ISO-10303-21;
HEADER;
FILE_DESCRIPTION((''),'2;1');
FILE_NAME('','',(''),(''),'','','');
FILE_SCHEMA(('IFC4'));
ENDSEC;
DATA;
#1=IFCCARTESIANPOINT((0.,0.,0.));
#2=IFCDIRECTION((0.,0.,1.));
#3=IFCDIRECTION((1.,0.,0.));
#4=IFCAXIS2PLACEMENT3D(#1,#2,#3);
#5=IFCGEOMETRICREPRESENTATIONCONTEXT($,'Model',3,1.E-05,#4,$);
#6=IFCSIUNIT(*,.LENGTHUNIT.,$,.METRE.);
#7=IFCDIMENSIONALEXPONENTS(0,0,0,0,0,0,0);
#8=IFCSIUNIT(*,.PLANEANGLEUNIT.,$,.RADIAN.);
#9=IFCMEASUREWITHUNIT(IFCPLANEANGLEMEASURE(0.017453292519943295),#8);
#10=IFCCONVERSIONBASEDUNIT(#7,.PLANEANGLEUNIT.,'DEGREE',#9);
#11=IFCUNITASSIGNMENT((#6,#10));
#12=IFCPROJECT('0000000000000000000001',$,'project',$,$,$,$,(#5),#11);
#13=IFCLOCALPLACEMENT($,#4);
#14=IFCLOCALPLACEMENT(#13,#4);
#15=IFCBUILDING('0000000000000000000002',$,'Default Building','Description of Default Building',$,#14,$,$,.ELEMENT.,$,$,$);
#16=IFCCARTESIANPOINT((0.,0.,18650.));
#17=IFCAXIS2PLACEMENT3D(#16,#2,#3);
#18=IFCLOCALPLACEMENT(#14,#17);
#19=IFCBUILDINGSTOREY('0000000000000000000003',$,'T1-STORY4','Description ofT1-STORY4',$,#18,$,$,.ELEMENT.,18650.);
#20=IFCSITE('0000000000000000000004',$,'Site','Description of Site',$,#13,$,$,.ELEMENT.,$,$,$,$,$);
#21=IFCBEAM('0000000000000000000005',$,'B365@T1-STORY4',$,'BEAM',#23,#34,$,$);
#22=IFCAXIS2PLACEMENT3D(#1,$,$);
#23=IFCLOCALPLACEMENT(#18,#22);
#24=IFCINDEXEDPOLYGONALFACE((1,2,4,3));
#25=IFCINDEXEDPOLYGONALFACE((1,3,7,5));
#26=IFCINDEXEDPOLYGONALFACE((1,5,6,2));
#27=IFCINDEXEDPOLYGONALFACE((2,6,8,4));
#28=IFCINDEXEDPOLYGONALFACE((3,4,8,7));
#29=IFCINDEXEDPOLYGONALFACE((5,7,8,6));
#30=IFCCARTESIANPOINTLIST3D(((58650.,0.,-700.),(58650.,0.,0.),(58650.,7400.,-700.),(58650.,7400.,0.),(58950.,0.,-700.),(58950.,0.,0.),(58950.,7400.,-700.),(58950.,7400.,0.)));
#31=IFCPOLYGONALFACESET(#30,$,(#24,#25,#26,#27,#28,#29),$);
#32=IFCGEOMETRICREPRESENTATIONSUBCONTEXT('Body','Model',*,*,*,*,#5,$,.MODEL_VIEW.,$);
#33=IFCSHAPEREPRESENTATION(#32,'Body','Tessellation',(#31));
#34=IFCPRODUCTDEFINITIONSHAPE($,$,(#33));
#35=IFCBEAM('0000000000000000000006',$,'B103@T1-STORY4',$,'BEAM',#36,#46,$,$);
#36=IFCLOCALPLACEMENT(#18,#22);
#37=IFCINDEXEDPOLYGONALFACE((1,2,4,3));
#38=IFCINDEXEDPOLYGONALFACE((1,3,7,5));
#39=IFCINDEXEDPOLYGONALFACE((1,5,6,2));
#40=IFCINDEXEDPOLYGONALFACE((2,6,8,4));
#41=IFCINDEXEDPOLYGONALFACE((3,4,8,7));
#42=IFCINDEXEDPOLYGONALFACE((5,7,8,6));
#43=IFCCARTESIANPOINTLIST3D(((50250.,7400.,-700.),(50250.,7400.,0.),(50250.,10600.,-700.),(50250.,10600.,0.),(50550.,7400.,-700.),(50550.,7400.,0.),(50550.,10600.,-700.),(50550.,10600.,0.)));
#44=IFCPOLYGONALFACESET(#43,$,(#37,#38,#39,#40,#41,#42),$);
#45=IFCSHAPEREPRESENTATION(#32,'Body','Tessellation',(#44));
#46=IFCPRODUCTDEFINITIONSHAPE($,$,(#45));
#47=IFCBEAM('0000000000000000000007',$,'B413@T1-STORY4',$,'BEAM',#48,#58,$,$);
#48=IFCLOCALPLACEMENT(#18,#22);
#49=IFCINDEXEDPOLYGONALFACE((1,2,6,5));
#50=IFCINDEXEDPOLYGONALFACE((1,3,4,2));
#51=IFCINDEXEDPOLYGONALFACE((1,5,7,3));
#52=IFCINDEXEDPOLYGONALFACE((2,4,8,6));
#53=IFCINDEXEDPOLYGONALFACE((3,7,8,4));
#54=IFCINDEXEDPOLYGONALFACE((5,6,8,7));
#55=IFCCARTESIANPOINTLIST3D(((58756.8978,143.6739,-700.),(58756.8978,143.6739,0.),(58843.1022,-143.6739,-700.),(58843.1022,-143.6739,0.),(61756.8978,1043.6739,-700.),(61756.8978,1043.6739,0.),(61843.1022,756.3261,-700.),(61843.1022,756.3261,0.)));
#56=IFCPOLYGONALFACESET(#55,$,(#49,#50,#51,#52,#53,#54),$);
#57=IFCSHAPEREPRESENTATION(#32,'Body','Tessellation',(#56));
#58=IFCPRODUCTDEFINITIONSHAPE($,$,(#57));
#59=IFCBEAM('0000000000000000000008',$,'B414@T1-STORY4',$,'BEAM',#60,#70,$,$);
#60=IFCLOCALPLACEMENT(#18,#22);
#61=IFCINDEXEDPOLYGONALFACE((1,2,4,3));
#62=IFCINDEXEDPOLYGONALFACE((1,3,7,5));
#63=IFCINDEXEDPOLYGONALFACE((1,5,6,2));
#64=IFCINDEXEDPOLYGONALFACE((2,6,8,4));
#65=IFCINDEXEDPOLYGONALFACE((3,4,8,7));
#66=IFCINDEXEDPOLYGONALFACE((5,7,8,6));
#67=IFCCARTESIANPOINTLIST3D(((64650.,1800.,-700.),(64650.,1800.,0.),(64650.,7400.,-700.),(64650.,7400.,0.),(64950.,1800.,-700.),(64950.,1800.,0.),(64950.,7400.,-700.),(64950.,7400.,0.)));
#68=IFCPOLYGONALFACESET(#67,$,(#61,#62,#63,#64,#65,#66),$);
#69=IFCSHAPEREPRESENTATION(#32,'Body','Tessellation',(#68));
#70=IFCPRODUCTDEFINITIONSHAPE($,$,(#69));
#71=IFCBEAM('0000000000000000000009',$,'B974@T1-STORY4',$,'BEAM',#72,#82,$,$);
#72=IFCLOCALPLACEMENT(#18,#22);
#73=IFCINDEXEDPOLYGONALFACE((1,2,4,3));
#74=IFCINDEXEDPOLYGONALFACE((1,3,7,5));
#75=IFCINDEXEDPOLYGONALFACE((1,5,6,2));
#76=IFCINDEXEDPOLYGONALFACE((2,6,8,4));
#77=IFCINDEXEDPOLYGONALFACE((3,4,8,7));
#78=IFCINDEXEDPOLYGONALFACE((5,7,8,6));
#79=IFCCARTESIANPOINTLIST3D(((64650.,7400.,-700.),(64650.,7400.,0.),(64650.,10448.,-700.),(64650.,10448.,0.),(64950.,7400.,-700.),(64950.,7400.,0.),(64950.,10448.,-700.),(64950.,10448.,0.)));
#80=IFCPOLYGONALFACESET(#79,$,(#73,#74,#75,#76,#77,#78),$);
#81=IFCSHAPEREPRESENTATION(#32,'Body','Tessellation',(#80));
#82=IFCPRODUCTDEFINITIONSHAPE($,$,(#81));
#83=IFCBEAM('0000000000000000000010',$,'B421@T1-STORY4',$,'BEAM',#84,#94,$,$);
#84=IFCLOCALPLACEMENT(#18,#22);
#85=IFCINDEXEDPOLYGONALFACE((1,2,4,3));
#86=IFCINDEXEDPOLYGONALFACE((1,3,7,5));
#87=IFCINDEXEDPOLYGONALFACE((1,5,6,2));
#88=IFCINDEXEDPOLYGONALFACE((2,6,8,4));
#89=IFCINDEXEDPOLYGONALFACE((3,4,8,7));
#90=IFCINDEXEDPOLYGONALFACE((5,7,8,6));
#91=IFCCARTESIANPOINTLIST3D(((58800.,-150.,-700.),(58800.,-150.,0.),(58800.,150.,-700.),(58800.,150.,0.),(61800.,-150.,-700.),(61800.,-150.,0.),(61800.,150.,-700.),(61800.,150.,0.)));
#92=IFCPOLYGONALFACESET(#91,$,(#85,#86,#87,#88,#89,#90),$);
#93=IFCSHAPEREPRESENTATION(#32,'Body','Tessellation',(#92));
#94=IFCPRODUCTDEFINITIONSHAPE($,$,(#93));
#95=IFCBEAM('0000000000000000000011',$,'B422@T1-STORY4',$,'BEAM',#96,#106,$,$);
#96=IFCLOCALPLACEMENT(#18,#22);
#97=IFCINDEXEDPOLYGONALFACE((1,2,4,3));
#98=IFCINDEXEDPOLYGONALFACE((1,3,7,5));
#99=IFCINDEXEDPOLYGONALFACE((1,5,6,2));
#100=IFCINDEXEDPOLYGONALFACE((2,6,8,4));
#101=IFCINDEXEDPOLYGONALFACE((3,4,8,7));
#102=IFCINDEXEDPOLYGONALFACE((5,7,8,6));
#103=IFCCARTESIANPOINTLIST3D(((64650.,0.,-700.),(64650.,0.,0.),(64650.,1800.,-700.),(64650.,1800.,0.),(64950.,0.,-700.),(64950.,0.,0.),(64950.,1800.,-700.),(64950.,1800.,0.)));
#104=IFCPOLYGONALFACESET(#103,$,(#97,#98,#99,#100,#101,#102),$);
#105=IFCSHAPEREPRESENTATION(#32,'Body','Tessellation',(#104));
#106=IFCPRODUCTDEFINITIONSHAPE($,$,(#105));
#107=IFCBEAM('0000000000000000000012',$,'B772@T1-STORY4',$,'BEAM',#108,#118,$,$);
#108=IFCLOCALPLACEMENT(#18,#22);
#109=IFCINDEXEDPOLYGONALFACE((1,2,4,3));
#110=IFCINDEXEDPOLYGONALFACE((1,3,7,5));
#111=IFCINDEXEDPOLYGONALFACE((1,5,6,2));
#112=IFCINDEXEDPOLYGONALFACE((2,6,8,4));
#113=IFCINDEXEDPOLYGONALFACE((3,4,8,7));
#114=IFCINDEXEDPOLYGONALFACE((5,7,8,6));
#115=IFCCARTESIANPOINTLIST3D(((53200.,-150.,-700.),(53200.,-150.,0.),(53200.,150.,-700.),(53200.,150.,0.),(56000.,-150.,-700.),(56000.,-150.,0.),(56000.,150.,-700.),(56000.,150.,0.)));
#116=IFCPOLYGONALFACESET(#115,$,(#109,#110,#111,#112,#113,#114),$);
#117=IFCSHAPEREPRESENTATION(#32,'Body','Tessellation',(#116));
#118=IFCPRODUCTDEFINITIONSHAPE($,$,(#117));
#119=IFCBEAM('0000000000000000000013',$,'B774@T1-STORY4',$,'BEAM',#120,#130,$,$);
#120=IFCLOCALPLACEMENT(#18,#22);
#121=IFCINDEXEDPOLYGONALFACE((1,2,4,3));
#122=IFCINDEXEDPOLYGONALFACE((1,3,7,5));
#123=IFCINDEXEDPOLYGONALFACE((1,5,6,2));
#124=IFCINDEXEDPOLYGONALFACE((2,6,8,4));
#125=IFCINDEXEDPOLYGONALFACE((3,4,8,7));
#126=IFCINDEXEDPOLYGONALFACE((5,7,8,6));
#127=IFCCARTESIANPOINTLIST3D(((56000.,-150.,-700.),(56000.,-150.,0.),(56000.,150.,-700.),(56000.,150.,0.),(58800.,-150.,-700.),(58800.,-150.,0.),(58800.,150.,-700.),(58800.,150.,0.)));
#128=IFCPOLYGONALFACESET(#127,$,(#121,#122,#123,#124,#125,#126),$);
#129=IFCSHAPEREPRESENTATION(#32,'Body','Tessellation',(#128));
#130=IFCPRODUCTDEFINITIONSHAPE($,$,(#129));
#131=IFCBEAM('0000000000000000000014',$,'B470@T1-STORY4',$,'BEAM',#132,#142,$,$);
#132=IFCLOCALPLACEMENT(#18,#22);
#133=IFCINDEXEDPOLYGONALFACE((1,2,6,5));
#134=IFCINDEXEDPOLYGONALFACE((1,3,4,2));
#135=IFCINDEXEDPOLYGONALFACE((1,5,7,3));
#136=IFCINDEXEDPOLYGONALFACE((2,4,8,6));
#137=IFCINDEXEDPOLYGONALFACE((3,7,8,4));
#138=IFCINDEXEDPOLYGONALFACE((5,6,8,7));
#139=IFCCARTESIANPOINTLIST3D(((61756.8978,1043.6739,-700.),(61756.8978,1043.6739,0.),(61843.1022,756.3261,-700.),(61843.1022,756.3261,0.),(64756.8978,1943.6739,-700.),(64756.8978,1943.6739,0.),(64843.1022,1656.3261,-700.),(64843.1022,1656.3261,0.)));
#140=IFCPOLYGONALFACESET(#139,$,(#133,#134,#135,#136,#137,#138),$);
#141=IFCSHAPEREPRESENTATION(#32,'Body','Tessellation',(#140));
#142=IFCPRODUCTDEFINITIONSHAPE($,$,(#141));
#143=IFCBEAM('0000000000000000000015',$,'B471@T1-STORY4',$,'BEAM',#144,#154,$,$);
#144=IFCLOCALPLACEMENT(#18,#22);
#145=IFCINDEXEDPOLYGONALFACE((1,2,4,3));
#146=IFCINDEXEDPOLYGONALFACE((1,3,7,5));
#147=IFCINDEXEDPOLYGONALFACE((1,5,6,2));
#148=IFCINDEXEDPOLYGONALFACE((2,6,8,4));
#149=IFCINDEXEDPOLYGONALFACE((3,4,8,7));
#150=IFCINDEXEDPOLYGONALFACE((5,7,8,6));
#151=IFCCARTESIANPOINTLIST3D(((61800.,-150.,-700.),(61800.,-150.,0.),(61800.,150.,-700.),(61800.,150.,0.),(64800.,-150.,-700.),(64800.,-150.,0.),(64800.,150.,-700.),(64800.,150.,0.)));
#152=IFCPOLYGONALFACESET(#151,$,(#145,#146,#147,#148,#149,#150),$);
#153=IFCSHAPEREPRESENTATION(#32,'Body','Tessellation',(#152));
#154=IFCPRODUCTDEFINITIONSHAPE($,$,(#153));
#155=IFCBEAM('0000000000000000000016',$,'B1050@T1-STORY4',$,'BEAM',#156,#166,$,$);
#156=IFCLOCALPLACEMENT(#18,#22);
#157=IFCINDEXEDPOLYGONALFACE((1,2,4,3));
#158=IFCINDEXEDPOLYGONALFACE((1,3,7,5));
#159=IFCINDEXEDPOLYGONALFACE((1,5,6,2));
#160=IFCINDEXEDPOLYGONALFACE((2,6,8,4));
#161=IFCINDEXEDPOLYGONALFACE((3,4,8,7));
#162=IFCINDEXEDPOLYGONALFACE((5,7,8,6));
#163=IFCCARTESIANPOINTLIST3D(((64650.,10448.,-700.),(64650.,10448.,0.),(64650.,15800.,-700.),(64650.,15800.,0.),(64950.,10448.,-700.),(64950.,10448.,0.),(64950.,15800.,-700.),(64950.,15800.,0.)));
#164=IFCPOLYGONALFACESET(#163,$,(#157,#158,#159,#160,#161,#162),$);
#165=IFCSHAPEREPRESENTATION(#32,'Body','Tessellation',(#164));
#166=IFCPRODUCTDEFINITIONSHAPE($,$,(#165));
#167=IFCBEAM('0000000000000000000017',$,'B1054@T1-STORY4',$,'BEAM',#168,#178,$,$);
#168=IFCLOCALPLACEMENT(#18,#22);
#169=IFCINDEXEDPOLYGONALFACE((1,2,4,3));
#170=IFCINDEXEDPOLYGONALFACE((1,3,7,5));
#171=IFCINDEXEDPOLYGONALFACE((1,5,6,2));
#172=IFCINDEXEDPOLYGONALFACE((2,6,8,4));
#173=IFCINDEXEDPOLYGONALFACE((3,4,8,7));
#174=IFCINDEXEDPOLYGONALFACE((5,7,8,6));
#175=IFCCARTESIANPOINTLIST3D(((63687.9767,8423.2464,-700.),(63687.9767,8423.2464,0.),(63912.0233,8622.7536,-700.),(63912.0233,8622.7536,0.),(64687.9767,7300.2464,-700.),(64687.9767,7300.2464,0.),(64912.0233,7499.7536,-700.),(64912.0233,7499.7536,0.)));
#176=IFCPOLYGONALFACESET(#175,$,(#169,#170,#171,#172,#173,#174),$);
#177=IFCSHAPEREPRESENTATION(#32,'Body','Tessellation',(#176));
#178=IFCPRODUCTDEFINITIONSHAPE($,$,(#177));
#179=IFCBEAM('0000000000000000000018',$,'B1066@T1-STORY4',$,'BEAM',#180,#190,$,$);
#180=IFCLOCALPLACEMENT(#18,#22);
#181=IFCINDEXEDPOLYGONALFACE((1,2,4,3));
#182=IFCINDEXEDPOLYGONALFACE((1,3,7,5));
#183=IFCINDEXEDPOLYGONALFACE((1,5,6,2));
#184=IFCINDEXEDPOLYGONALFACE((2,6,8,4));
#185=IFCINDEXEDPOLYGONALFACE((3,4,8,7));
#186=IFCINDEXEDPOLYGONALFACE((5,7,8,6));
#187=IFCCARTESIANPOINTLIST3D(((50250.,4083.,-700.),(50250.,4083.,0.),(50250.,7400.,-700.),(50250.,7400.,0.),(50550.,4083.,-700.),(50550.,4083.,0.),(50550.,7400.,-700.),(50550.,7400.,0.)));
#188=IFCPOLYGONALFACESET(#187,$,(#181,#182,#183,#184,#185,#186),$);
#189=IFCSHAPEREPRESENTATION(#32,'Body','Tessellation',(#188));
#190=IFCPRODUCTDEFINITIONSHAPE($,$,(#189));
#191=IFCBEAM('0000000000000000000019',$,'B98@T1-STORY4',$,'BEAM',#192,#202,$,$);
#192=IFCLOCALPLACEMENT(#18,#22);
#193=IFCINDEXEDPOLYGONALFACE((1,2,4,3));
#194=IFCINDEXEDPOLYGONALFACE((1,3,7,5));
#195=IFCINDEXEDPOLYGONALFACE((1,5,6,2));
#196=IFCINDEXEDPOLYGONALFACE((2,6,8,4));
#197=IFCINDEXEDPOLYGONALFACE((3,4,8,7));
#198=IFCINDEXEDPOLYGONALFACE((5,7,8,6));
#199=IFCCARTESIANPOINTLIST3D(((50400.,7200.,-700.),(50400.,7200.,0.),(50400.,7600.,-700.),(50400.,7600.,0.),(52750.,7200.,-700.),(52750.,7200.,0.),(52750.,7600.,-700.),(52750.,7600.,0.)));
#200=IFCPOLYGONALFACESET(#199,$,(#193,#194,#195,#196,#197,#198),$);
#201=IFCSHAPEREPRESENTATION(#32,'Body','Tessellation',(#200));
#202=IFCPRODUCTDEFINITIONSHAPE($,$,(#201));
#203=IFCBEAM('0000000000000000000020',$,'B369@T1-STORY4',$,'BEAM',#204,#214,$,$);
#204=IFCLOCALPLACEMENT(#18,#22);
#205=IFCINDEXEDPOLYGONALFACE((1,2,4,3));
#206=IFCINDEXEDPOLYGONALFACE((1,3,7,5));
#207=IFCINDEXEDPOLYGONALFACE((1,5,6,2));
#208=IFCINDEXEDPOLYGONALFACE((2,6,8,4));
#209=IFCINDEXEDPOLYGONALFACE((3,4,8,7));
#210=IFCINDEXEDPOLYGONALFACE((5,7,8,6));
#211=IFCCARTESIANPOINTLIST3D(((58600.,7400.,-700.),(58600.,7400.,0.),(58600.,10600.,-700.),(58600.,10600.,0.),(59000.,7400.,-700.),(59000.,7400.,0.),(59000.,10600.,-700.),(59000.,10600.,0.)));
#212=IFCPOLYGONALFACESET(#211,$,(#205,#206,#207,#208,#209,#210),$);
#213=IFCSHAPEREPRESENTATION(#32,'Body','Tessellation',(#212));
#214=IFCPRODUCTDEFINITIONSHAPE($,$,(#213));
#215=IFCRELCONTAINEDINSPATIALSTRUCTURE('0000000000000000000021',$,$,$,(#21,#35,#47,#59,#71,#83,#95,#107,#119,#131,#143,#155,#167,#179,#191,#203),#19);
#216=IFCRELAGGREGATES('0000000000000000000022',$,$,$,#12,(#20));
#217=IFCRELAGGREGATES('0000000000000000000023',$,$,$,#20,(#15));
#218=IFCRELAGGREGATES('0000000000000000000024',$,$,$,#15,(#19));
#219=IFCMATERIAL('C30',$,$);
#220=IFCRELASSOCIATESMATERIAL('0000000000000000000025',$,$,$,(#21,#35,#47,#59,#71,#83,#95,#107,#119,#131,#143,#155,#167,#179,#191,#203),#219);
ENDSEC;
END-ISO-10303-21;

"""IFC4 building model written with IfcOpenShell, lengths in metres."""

from ifc_helpers import new_model, entity, si_unit, converted_unit, frame, origin_with_axes, place, context, subcontext, project, spatial, rectangle, extrude, material, element, save


model = new_model("IFC4")

# Units and contexts
model_context = context("Model", 3, precision=1e-05, world=origin_with_axes())
body_context = subcontext(model_context, "Body", "Model", "MODEL_VIEW")
ifc_project = project(units=[si_unit("LENGTHUNIT", "METRE"), converted_unit("PLANEANGLEUNIT", "DEGREE", entity("IfcPlaneAngleMeasure", 0.017453292519943295), si_unit("PLANEANGLEUNIT", "RADIAN"), dimensions=[0, 0, 0, 0, 0, 0, 0])], contexts=[model_context])

# Site, building, storey
site_placement = place(None, origin_with_axes())
site = spatial("IfcSite", under=ifc_project, at=site_placement, Name="Site", Description="Description of Site", CompositionType="ELEMENT")
building_placement = place(site_placement, origin_with_axes())
building = spatial("IfcBuilding", under=site, at=building_placement, Name="Default Building", Description="Description of Default Building", CompositionType="ELEMENT")
storey_placement = place(building_placement, frame((0.0, 0.0, 18650.0), z_axis=(0.0, 0.0, 1.0), x_axis=(1.0, 0.0, 0.0)))
storey = spatial("IfcBuildingStorey", under=building, at=storey_placement, Name="T1-STORY4", Description="Description ofT1-STORY4", CompositionType="ELEMENT", Elevation=18650.0)

# Beams
ifc_material_1 = material(Name="C30")
beam_1_placement = place(storey_placement, frame((58800.0, 0.0, -350.0), z_axis=(0.0, 1.0, 0.0), x_axis=(-1.0, 0.0, 0.0)))
element("IfcBeam", 1, at=beam_1_placement, inside=storey, material=ifc_material_1, Name="B365@T1-STORY4", ObjectType="BEAM", context=body_context, shape_type="SweptSolid", body=[
    extrude(rectangle(XDim=300.0, YDim=700.0), origin_with_axes(), (0.0, 0.0, 1.0), 7400.0),
])
beam_2_placement = place(storey_placement, frame((50400.0, 7400.0, -350.0), z_axis=(0.0, 1.0, 0.0), x_axis=(-1.0, 0.0, 0.0)))
element("IfcBeam", 2, at=beam_2_placement, inside=storey, material=ifc_material_1, Name="B103@T1-STORY4", ObjectType="BEAM", context=body_context, shape_type="SweptSolid", body=[
    extrude(rectangle(XDim=300.0, YDim=700.0), origin_with_axes(), (0.0, 0.0, 1.0), 3200.0),
])
beam_3_placement = place(storey_placement, frame((58800.0, 0.0, -350.0), z_axis=(0.957826, 0.287348, 0.0), x_axis=(-0.287348, 0.957826, 0.0)))
element("IfcBeam", 3, at=beam_3_placement, inside=storey, material=ifc_material_1, Name="B413@T1-STORY4", ObjectType="BEAM", context=body_context, shape_type="SweptSolid", body=[
    extrude(rectangle(XDim=300.0, YDim=700.0), origin_with_axes(), (0.0, 0.0, 1.0), 3132.092),
])
beam_4_placement = place(storey_placement, frame((64800.0, 1800.0, -350.0), z_axis=(0.0, 1.0, 0.0), x_axis=(-1.0, 0.0, 0.0)))
element("IfcBeam", 4, at=beam_4_placement, inside=storey, material=ifc_material_1, Name="B414@T1-STORY4", ObjectType="BEAM", context=body_context, shape_type="SweptSolid", body=[
    extrude(rectangle(XDim=300.0, YDim=700.0), origin_with_axes(), (0.0, 0.0, 1.0), 5600.0),
])
beam_5_placement = place(storey_placement, frame((64800.0, 7400.0, -350.0), z_axis=(0.0, 1.0, 0.0), x_axis=(-1.0, 0.0, 0.0)))
element("IfcBeam", 5, at=beam_5_placement, inside=storey, material=ifc_material_1, Name="B974@T1-STORY4", ObjectType="BEAM", context=body_context, shape_type="SweptSolid", body=[
    extrude(rectangle(XDim=300.0, YDim=700.0), origin_with_axes(), (0.0, 0.0, 1.0), 3048.0),
])
beam_6_placement = place(storey_placement, frame((58800.0, 0.0, -350.0), z_axis=(1.0, 0.0, 0.0), x_axis=(0.0, 1.0, 0.0)))
element("IfcBeam", 6, at=beam_6_placement, inside=storey, material=ifc_material_1, Name="B421@T1-STORY4", ObjectType="BEAM", context=body_context, shape_type="SweptSolid", body=[
    extrude(rectangle(XDim=300.0, YDim=700.0), origin_with_axes(), (0.0, 0.0, 1.0), 3000.0),
])
beam_7_placement = place(storey_placement, frame((64800.0, 0.0, -350.0), z_axis=(0.0, 1.0, 0.0), x_axis=(-1.0, 0.0, 0.0)))
element("IfcBeam", 7, at=beam_7_placement, inside=storey, material=ifc_material_1, Name="B422@T1-STORY4", ObjectType="BEAM", context=body_context, shape_type="SweptSolid", body=[
    extrude(rectangle(XDim=300.0, YDim=700.0), origin_with_axes(), (0.0, 0.0, 1.0), 1800.0),
])
for number, where, z_axis, x_axis, name in (
    (8, (53200.0, 0.0, -350.0), (1.0, 0.0, 0.0), (0.0, 1.0, 0.0), "B772@T1-STORY4"),
    (9, (56000.0, 0.0, -350.0), (1.0, 0.0, 0.0), (0.0, 1.0, 0.0), "B774@T1-STORY4"),
):
    element("IfcBeam", number, at=place(storey_placement, frame(where, z_axis=z_axis, x_axis=x_axis)), inside=storey, material=ifc_material_1, Name=name, ObjectType="BEAM", context=body_context, shape_type="SweptSolid", body=[
        extrude(rectangle(XDim=300.0, YDim=700.0), origin_with_axes(), (0.0, 0.0, 1.0), 2800.0),
    ])
beam_8_placement = place(storey_placement, frame((61800.0, 900.0, -350.0), z_axis=(0.957826, 0.287348, 0.0), x_axis=(-0.287348, 0.957826, 0.0)))
element("IfcBeam", 10, at=beam_8_placement, inside=storey, material=ifc_material_1, Name="B470@T1-STORY4", ObjectType="BEAM", context=body_context, shape_type="SweptSolid", body=[
    extrude(rectangle(XDim=300.0, YDim=700.0), origin_with_axes(), (0.0, 0.0, 1.0), 3132.092),
])
beam_9_placement = place(storey_placement, frame((61800.0, 0.0, -350.0), z_axis=(1.0, 0.0, 0.0), x_axis=(0.0, 1.0, 0.0)))
element("IfcBeam", 11, at=beam_9_placement, inside=storey, material=ifc_material_1, Name="B471@T1-STORY4", ObjectType="BEAM", context=body_context, shape_type="SweptSolid", body=[
    extrude(rectangle(XDim=300.0, YDim=700.0), origin_with_axes(), (0.0, 0.0, 1.0), 3000.0),
])
beam_10_placement = place(storey_placement, frame((64800.0, 10448.0, -350.0), z_axis=(0.0, 1.0, 0.0), x_axis=(-1.0, 0.0, 0.0)))
element("IfcBeam", 12, at=beam_10_placement, inside=storey, material=ifc_material_1, Name="B1050@T1-STORY4", ObjectType="BEAM", context=body_context, shape_type="SweptSolid", body=[
    extrude(rectangle(XDim=300.0, YDim=700.0), origin_with_axes(), (0.0, 0.0, 1.0), 5352.0),
])
beam_11_placement = place(storey_placement, frame((63800.0, 8523.0, -350.0), z_axis=(0.665024, -0.746822, 0.0), x_axis=(0.746822, 0.665024, 0.0)))
element("IfcBeam", 13, at=beam_11_placement, inside=storey, material=ifc_material_1, Name="B1054@T1-STORY4", ObjectType="BEAM", context=body_context, shape_type="SweptSolid", body=[
    extrude(rectangle(XDim=300.0, YDim=700.0), origin_with_axes(), (0.0, 0.0, 1.0), 1503.7051),
])
beam_12_placement = place(storey_placement, frame((50400.0, 4083.0, -350.0), z_axis=(0.0, 1.0, 0.0), x_axis=(-1.0, 0.0, 0.0)))
element("IfcBeam", 14, at=beam_12_placement, inside=storey, material=ifc_material_1, Name="B1066@T1-STORY4", ObjectType="BEAM", context=body_context, shape_type="SweptSolid", body=[
    extrude(rectangle(XDim=300.0, YDim=700.0), origin_with_axes(), (0.0, 0.0, 1.0), 3317.0),
])
beam_13_placement = place(storey_placement, frame((50400.0, 7400.0, -350.0), z_axis=(1.0, 0.0, 0.0), x_axis=(0.0, 1.0, 0.0)))
element("IfcBeam", 15, at=beam_13_placement, inside=storey, material=ifc_material_1, Name="B98@T1-STORY4", ObjectType="BEAM", context=body_context, shape_type="SweptSolid", body=[
    extrude(rectangle(XDim=400.0, YDim=700.0), origin_with_axes(), (0.0, 0.0, 1.0), 2350.0),
])
beam_14_placement = place(storey_placement, frame((58800.0, 7400.0, -350.0), z_axis=(0.0, 1.0, 0.0), x_axis=(-1.0, 0.0, 0.0)))
element("IfcBeam", 16, at=beam_14_placement, inside=storey, material=ifc_material_1, Name="B369@T1-STORY4", ObjectType="BEAM", context=body_context, shape_type="SweptSolid", body=[
    extrude(rectangle(XDim=400.0, YDim=700.0), origin_with_axes(), (0.0, 0.0, 1.0), 3200.0),
])

save(model, "model.ifc")
